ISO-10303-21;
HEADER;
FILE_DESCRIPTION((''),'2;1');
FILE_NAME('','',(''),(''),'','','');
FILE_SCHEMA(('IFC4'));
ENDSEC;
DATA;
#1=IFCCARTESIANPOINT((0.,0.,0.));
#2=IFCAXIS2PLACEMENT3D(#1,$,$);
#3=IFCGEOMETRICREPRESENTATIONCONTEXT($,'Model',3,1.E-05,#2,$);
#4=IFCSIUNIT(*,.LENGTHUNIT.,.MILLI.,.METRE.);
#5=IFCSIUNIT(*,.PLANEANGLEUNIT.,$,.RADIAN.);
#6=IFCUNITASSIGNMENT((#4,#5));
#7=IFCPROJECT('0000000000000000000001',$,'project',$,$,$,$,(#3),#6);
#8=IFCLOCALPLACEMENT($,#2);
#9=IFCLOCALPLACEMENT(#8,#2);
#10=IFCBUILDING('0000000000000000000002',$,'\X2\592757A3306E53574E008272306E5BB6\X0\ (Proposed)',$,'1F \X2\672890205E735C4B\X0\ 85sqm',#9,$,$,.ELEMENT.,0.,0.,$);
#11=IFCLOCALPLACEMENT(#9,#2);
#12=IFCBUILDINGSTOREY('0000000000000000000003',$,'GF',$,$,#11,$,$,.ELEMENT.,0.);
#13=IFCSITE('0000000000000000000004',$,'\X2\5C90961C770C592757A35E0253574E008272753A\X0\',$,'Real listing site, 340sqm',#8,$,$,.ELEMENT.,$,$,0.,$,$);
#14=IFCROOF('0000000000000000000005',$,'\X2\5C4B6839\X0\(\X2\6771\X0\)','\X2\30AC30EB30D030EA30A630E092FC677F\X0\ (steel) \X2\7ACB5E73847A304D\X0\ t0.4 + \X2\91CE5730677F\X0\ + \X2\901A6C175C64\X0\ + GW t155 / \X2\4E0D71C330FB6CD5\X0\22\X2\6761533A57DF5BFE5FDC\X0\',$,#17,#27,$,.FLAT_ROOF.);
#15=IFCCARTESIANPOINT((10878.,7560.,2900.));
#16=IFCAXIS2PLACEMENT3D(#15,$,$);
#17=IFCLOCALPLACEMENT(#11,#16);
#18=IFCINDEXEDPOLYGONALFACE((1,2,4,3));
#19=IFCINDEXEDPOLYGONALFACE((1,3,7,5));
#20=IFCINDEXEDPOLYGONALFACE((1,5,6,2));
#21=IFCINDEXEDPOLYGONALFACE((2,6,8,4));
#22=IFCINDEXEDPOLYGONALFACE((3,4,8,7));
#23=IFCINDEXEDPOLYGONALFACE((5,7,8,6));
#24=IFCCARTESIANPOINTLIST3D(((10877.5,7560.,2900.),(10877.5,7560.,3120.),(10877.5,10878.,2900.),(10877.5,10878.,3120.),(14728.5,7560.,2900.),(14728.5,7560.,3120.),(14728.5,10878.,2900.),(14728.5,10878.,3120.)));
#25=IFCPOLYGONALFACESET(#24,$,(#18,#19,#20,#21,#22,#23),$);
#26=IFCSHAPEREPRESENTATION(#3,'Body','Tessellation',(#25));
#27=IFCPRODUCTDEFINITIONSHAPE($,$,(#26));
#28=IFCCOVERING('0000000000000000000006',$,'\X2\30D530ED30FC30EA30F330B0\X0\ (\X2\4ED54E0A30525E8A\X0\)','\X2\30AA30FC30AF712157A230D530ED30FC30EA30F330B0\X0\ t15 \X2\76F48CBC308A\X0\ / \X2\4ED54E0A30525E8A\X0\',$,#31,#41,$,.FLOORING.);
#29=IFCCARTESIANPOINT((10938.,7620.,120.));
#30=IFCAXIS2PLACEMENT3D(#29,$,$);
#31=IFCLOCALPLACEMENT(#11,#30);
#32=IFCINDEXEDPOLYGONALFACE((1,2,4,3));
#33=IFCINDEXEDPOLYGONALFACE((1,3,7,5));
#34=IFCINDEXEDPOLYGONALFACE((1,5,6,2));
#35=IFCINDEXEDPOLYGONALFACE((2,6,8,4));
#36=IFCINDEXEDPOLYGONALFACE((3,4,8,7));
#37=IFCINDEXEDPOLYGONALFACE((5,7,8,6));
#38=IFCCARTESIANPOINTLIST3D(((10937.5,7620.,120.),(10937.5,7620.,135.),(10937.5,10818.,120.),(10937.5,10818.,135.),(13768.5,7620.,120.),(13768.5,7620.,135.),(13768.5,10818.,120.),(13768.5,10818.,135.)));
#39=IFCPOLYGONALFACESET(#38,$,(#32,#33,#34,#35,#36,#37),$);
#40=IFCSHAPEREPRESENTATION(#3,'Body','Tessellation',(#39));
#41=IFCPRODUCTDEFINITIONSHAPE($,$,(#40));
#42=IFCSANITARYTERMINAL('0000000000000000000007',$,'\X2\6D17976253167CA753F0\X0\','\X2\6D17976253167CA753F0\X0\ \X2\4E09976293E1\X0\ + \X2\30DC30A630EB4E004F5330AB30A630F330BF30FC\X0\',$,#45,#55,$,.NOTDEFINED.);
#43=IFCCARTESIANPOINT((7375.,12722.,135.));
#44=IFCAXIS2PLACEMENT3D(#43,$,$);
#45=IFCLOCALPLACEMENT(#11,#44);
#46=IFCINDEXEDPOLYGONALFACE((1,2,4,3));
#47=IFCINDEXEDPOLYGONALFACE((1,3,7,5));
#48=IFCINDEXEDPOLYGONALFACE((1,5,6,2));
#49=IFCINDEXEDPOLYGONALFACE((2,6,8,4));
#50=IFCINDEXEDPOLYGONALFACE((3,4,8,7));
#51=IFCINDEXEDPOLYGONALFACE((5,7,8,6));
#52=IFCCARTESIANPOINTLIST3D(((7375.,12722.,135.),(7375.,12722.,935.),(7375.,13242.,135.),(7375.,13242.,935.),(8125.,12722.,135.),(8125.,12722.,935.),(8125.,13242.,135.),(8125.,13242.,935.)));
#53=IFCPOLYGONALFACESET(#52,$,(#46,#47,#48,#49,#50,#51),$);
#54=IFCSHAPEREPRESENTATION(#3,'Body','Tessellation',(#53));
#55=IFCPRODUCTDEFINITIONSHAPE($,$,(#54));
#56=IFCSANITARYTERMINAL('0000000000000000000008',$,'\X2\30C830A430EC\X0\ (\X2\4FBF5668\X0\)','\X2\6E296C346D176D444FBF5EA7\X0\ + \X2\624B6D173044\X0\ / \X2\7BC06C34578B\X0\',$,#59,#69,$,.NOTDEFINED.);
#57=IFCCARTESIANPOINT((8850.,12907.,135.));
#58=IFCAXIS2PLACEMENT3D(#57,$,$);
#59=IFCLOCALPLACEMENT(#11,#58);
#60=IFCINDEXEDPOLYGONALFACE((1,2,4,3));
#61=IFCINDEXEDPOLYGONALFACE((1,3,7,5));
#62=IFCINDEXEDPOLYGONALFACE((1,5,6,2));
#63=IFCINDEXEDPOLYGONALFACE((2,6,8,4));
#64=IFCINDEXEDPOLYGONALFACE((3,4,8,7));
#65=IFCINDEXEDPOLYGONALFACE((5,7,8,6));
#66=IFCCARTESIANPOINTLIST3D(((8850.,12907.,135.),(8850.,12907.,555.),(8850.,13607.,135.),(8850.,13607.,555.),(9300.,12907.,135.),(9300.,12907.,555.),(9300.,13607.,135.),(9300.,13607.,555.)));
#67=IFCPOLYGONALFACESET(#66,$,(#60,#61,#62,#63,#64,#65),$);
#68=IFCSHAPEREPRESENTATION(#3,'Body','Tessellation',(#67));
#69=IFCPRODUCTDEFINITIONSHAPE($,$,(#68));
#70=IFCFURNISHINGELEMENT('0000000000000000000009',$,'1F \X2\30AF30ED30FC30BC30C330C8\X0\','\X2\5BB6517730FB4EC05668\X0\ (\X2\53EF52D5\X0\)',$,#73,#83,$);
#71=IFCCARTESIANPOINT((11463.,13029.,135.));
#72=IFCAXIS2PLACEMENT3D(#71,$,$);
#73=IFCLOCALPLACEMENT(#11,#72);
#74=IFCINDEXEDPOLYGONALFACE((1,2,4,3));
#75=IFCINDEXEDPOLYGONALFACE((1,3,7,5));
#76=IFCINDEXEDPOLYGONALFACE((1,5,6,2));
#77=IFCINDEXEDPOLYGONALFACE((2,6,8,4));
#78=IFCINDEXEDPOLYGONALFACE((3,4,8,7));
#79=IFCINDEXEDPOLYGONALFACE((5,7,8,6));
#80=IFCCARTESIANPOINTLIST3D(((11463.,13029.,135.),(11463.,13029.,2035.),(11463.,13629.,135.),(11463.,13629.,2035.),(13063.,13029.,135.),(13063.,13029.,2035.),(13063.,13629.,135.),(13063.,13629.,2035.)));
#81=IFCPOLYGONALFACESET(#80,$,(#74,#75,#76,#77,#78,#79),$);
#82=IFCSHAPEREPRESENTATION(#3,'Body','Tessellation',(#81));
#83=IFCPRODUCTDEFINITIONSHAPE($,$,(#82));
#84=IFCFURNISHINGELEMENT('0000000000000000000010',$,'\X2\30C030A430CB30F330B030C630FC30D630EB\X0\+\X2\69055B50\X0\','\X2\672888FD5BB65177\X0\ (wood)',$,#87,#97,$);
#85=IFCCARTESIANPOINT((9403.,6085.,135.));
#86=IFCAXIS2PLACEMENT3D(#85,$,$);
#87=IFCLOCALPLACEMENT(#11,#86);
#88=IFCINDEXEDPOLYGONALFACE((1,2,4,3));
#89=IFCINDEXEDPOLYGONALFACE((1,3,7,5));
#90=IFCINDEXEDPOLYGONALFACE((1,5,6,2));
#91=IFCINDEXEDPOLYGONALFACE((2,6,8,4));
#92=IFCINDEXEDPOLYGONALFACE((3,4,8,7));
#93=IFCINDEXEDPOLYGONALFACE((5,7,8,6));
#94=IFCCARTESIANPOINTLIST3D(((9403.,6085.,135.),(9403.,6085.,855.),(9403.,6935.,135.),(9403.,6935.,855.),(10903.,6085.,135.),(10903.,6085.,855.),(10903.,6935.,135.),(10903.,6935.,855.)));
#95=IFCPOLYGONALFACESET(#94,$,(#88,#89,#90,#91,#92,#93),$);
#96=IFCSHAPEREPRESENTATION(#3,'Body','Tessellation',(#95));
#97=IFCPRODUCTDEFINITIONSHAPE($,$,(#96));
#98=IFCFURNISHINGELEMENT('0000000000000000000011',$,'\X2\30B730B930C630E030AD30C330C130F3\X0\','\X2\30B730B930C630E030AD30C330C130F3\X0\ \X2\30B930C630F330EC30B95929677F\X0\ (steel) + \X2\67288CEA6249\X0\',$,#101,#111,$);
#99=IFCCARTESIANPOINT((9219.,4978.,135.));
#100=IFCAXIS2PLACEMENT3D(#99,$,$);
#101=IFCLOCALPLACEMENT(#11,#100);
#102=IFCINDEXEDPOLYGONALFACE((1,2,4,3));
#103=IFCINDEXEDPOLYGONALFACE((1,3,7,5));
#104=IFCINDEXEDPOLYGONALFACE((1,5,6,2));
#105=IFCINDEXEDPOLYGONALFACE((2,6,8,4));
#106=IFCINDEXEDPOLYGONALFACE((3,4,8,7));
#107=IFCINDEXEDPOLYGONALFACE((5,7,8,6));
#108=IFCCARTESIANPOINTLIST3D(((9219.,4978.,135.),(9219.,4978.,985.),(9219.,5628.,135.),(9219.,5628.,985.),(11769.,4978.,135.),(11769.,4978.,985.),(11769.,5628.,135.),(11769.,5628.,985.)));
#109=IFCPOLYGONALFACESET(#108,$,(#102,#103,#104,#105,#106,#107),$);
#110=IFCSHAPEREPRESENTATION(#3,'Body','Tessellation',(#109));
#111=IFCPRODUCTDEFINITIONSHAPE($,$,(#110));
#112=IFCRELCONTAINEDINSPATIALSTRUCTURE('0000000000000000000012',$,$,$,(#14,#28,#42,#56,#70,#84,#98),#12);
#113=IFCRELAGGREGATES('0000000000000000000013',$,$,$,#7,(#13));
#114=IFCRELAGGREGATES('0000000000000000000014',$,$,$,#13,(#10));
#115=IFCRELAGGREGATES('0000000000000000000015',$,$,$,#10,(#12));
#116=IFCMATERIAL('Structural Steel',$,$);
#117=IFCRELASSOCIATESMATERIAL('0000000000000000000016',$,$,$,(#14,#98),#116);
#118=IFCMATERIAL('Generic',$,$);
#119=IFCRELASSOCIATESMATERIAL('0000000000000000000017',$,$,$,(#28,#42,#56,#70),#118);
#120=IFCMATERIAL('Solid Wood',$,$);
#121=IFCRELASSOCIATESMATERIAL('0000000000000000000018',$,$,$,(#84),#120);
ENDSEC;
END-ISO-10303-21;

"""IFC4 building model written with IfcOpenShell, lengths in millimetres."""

from ifc_helpers import new_model, si_unit, frame, frame_2d, origin, place, context, project, spatial, rectangle, extrude, material, element, save


model = new_model("IFC4")

# Units and contexts
model_context = context("Model", 3, precision=1e-05, world=origin())
ifc_project = project(units=[si_unit("LENGTHUNIT", "METRE", prefix="MILLI"), si_unit("PLANEANGLEUNIT", "RADIAN")], contexts=[model_context])

# Site, building, storey
site_placement = place(None, origin())
site = spatial("IfcSite", under=ifc_project, at=site_placement, Name="岐阜県大垣市南一色町", ObjectType="Real listing site, 340sqm", CompositionType="ELEMENT", RefElevation=0.0)
building_placement = place(site_placement, origin())
building = spatial("IfcBuilding", under=site, at=building_placement, Name="大垣の南一色の家 (Proposed)", ObjectType="1F 木造平屋 85sqm", CompositionType="ELEMENT", ElevationOfRefHeight=0.0, ElevationOfTerrain=0.0)
storey_placement = place(building_placement, origin())
storey = spatial("IfcBuildingStorey", under=building, at=storey_placement, Name="GF", CompositionType="ELEMENT", Elevation=0.0)

# Shared definitions
ifc_material_1 = material(Name="Solid Wood")

# Roof
ifc_material_2 = material(Name="Structural Steel")
roof_placement = place(storey_placement, frame((10878.0, 7560.0, 2900.0)))
element("IfcRoof", 1, at=roof_placement, inside=storey, material=ifc_material_2, Name="屋根(東)", Description="ガルバリウム鋼板 (steel) 立平葺き t0.4 + 野地板 + 通気層 + GW t155 / 不燃・法22条区域対応", PredefinedType="FLAT_ROOF", context=model_context, shape_type="SweptSolid", body=[
    extrude(rectangle(XDim=3851.0, YDim=3318.0, at=frame_2d((1925.0, 1659.0))), frame((10878.0, 7560.0, 2900.0)), (0.0, 0.0, 1.0), 220.0),
])

# Covering
ifc_material_3 = material(Name="Generic")
covering_placement = place(storey_placement, frame((10938.0, 7620.0, 120.0)))
element("IfcCovering", 2, at=covering_placement, inside=storey, material=ifc_material_3, Name="フローリング (仕上げ床)", Description="オーク無垢フローリング t15 直貼り / 仕上げ床", PredefinedType="FLOORING", context=model_context, shape_type="SweptSolid", body=[
    extrude(rectangle(XDim=2831.0, YDim=3198.0, at=frame_2d((1415.0, 1599.0))), frame((10938.0, 7620.0, 120.0)), (0.0, 0.0, 1.0), 15.0),
])

# Sanitary terminals
sanitary_terminal_1_placement = place(storey_placement, frame((7375.0, 12722.0, 135.0)))
element("IfcSanitaryTerminal", 3, at=sanitary_terminal_1_placement, inside=storey, material=ifc_material_3, Name="洗面化粧台", Description="洗面化粧台 三面鏡 + ボウル一体カウンター", PredefinedType="NOTDEFINED", context=model_context, shape_type="SweptSolid", body=[
    extrude(rectangle(XDim=750.0, YDim=520.0, at=frame_2d((375.0, 260.0))), frame((7375.0, 12722.0, 135.0)), (0.0, 0.0, 1.0), 800.0),
])
sanitary_terminal_2_placement = place(storey_placement, frame((8850.0, 12907.0, 135.0)))
element("IfcSanitaryTerminal", 4, at=sanitary_terminal_2_placement, inside=storey, material=ifc_material_3, Name="トイレ (便器)", Description="温水洗浄便座 + 手洗い / 節水型", PredefinedType="NOTDEFINED", context=model_context, shape_type="SweptSolid", body=[
    extrude(rectangle(XDim=450.0, YDim=700.0, at=frame_2d((225.0, 350.0))), frame((8850.0, 12907.0, 135.0)), (0.0, 0.0, 1.0), 420.0),
])

# Furnishing elements
furnishing_1_placement = place(storey_placement, frame((11463.0, 13029.0, 135.0)))
element("IfcFurnishingElement", 5, at=furnishing_1_placement, inside=storey, material=ifc_material_3, Name="1F クローゼット", Description="家具・什器 (可動)", context=model_context, shape_type="SweptSolid", body=[
    extrude(rectangle(XDim=1600.0, YDim=600.0, at=frame_2d((800.0, 300.0))), frame((11463.0, 13029.0, 135.0)), (0.0, 0.0, 1.0), 1900.0),
])
furnishing_2_placement = place(storey_placement, frame((9403.0, 6085.0, 135.0)))
element("IfcFurnishingElement", 6, at=furnishing_2_placement, inside=storey, material=ifc_material_1, Name="ダイニングテーブル+椅子", Description="木製家具 (wood)", context=model_context, shape_type="SweptSolid", body=[
    extrude(rectangle(XDim=1500.0, YDim=850.0, at=frame_2d((750.0, 425.0))), frame((9403.0, 6085.0, 135.0)), (0.0, 0.0, 1.0), 720.0),
])
furnishing_3_placement = place(storey_placement, frame((9219.0, 4978.0, 135.0)))
element("IfcFurnishingElement", 7, at=furnishing_3_placement, inside=storey, material=ifc_material_2, Name="システムキッチン", Description="システムキッチン ステンレス天板 (steel) + 木質扉", context=model_context, shape_type="SweptSolid", body=[
    extrude(rectangle(XDim=2550.0, YDim=650.0, at=frame_2d((1275.0, 325.0))), frame((9219.0, 4978.0, 135.0)), (0.0, 0.0, 1.0), 850.0),
])

save(model, "model.ifc")
